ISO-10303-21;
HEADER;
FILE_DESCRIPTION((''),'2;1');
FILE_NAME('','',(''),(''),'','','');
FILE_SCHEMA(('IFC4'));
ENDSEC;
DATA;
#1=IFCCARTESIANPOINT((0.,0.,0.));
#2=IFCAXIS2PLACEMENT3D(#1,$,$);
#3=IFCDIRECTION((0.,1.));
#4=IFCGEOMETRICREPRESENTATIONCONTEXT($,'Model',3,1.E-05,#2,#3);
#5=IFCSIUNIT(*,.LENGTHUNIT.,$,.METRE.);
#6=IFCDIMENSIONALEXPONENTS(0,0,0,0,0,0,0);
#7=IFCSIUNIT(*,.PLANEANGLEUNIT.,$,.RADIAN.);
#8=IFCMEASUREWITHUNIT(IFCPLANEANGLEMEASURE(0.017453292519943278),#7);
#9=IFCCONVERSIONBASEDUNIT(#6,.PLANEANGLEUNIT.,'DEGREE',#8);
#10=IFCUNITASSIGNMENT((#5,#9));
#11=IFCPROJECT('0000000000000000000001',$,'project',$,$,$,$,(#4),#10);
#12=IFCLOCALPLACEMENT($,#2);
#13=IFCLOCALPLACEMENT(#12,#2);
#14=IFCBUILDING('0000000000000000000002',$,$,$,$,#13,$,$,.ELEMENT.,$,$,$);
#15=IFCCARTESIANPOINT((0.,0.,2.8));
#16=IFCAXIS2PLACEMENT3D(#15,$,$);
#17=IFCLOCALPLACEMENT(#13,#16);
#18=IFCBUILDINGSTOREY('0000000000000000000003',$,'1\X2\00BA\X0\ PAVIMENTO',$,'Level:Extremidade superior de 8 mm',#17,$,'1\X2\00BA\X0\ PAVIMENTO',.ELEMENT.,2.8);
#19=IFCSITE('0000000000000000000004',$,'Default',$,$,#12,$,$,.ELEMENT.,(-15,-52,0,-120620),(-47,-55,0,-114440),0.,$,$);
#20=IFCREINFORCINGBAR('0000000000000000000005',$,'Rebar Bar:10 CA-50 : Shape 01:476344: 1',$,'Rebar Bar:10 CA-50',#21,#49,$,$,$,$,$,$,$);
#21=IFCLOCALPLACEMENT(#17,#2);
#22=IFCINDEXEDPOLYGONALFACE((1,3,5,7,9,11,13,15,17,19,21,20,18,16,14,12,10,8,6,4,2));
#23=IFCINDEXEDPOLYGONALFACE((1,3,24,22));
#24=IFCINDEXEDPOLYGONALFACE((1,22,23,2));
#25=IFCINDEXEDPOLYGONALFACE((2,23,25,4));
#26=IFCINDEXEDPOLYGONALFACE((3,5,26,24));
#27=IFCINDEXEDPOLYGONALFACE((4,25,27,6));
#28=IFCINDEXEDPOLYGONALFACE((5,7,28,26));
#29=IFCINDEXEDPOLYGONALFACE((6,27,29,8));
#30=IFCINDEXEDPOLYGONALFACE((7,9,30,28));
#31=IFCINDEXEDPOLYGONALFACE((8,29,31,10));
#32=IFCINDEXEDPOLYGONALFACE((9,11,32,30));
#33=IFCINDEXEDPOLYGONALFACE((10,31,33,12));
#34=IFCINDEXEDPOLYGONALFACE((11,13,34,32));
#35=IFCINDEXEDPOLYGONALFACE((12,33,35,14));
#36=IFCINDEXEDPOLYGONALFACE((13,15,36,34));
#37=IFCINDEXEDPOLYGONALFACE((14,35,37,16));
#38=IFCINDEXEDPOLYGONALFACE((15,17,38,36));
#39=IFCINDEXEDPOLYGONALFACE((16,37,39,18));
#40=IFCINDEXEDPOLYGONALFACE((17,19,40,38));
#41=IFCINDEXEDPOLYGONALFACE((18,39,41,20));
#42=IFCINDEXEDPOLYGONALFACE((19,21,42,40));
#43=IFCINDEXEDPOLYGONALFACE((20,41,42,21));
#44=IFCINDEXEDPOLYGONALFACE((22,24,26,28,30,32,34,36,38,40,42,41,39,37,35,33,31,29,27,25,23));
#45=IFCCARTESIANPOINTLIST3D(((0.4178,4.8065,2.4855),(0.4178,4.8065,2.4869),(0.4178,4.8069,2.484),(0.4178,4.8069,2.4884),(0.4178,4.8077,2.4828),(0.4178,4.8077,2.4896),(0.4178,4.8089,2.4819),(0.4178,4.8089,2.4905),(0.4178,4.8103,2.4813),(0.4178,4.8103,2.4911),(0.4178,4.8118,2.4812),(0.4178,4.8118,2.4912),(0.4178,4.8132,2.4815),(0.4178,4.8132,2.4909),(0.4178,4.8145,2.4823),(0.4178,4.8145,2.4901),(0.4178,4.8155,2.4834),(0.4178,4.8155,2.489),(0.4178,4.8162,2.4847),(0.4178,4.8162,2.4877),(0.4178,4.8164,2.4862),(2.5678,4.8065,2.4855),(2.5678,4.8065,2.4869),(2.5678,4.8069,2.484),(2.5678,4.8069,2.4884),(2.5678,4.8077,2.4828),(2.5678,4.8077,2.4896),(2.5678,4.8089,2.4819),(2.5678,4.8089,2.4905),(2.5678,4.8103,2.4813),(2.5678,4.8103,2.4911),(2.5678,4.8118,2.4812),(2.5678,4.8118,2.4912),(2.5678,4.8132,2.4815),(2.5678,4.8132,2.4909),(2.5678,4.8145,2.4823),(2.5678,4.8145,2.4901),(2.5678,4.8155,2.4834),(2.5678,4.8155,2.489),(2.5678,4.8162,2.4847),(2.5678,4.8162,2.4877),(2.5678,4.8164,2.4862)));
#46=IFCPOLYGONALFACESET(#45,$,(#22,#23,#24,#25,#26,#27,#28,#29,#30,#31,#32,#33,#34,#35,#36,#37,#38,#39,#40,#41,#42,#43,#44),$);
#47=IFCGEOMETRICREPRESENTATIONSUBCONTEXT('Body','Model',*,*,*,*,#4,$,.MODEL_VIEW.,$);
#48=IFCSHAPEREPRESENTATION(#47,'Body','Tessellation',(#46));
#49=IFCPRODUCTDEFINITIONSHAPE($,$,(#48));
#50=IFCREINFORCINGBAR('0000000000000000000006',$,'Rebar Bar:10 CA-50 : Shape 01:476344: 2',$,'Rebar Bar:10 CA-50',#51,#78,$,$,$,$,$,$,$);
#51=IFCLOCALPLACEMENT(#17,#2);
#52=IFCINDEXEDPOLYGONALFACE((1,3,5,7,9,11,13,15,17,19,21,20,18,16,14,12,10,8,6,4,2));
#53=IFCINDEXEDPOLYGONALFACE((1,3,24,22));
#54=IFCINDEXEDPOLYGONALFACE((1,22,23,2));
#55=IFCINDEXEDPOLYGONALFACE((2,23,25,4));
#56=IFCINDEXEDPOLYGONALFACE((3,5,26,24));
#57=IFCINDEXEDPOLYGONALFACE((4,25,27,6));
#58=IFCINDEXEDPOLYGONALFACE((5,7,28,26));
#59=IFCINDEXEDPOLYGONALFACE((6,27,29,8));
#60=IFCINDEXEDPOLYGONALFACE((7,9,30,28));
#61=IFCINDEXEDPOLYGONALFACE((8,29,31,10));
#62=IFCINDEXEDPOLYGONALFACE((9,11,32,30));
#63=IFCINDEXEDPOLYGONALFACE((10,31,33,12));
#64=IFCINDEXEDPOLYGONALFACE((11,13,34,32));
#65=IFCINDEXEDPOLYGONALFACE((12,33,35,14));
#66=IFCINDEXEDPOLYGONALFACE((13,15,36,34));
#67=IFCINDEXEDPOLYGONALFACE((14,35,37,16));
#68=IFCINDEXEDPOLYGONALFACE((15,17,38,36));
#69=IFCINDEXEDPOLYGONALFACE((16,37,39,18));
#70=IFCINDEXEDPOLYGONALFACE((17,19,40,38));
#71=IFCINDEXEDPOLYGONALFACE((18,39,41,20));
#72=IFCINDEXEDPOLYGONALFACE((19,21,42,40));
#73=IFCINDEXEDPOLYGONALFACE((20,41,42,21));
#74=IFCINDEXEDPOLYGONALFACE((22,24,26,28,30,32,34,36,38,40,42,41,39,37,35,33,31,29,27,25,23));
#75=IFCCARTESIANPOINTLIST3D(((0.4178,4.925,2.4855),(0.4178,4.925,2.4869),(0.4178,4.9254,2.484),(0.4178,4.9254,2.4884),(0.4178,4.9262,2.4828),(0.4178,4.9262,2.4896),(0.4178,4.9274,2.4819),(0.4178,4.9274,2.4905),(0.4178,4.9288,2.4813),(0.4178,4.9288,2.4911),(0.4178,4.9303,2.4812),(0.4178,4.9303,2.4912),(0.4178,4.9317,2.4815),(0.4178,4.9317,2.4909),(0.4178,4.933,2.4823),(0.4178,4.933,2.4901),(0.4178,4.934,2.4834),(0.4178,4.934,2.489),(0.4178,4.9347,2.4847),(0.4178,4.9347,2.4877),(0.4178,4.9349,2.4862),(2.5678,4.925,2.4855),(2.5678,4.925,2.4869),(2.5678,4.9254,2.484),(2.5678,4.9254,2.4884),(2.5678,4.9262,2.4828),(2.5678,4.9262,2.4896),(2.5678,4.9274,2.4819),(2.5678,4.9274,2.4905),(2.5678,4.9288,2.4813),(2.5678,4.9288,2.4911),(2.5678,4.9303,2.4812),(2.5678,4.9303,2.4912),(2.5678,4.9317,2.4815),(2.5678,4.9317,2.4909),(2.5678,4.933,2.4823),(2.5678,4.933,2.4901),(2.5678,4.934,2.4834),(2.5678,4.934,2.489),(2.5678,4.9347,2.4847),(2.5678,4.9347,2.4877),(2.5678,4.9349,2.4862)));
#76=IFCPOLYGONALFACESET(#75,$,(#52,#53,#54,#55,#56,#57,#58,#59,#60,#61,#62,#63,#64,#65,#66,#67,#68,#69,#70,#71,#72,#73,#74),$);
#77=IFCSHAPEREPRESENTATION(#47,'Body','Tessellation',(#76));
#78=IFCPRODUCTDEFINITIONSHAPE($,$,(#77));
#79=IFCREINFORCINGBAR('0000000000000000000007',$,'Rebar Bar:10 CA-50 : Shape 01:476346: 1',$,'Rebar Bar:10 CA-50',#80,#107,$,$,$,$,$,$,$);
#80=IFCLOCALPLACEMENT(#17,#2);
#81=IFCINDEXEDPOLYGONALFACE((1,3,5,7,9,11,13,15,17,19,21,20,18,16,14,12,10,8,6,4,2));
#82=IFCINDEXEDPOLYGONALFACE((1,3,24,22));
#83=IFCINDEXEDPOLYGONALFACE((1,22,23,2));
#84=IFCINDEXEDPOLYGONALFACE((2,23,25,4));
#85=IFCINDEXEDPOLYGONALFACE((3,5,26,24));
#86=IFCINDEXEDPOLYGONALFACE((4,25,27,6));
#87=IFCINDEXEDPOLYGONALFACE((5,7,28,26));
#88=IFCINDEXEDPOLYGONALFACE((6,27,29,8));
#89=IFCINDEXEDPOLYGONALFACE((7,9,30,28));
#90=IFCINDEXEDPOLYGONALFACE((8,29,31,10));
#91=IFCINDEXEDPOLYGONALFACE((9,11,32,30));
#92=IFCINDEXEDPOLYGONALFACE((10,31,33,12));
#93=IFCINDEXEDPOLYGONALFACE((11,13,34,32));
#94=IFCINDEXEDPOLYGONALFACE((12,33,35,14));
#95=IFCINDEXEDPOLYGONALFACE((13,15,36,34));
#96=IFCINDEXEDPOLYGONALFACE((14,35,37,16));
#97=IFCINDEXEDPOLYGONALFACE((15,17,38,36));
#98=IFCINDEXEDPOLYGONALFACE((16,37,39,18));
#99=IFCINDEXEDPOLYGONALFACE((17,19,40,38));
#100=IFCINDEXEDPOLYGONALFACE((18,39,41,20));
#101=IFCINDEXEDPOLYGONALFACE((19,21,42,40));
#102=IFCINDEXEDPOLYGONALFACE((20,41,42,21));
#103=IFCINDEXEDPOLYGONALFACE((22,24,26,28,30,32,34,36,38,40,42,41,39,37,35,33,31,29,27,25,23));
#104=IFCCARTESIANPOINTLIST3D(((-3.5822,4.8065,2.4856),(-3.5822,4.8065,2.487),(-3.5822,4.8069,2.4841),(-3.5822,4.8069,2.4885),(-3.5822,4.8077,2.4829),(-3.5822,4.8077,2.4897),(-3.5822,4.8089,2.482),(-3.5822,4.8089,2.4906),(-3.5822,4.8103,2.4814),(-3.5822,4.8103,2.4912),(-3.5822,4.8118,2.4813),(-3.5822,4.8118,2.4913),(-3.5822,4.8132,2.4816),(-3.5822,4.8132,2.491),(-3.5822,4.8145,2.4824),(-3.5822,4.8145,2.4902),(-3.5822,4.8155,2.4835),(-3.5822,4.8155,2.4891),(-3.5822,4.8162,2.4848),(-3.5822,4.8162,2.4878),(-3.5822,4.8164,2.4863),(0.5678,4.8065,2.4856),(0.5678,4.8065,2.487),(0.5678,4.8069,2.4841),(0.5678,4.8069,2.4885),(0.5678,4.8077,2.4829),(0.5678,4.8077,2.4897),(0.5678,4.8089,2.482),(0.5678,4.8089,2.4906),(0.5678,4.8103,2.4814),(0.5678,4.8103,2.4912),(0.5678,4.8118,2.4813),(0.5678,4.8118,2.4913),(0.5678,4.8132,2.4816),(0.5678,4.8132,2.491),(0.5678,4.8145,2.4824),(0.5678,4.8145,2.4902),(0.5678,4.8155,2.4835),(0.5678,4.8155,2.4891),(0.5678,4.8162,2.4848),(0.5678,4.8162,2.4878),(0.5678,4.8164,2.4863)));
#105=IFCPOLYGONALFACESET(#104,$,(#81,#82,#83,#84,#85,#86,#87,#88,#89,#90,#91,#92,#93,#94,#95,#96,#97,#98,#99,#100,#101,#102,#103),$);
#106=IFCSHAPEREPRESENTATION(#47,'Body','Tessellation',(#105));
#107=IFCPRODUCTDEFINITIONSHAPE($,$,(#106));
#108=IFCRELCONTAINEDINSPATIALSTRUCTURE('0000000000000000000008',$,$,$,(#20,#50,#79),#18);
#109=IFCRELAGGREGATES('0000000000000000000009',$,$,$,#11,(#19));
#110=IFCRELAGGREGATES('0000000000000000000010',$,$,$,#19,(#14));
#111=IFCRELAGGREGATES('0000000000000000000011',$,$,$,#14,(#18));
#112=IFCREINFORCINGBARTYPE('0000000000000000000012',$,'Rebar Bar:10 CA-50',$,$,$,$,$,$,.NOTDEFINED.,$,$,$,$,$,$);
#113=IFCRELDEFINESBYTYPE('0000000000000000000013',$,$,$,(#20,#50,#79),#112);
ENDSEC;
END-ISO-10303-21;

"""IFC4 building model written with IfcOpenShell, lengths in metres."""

from ifc_helpers import new_model, entity, si_unit, converted_unit, direction, frame, origin, place, context, subcontext, project, spatial, type_object, element, save


model = new_model("IFC4")

# Units and contexts
model_context = context("Model", 3, precision=1e-05, world=origin(), true_north=direction((0.0, 1.0)))
body_context = subcontext(model_context, "Body", "Model", "MODEL_VIEW")
ifc_project = project(units=[si_unit("LENGTHUNIT", "METRE"), converted_unit("PLANEANGLEUNIT", "DEGREE", entity("IfcPlaneAngleMeasure", 0.017453292519943278), si_unit("PLANEANGLEUNIT", "RADIAN"), dimensions=[0, 0, 0, 0, 0, 0, 0])], contexts=[model_context])

# Site, building, storey
site_placement = place(None, origin())
site = spatial("IfcSite", under=ifc_project, at=site_placement, Name="Default", CompositionType="ELEMENT", RefLatitude=(-15, -52, 0, -120620), RefLongitude=(-47, -55, 0, -114440), RefElevation=0.0)
building_placement = place(site_placement, origin())
building = spatial("IfcBuilding", under=site, at=building_placement, CompositionType="ELEMENT")
storey_placement = place(building_placement, frame((0.0, 0.0, 2.8)))
storey = spatial("IfcBuildingStorey", under=building, at=storey_placement, Name="1º PAVIMENTO", ObjectType="Level:Extremidade superior de 8 mm", LongName="1º PAVIMENTO", CompositionType="ELEMENT", Elevation=2.8)

# Reinforcing bars
reinforcing_bar_type_1 = type_object("IfcReinforcingBarType", Name="Rebar Bar:10 CA-50", PredefinedType="NOTDEFINED")
reinforcing_bar_1_placement = place(storey_placement, origin())
element("IfcReinforcingBar", 1, at=reinforcing_bar_1_placement, inside=storey, type_object=reinforcing_bar_type_1, Name="Rebar Bar:10 CA-50 : Shape 01:476344: 1", ObjectType="Rebar Bar:10 CA-50", context=body_context, shape_type="AdvancedSweptSolid", body=[
    entity("IfcSweptDiskSolid", entity("IfcIndexedPolyCurve", entity("IfcCartesianPointList3D", [[0.4178, 4.8114, 2.4862], [2.5678, 4.8114, 2.4862]]), None, False), 0.005, None, 0.0, 1.0),
])
reinforcing_bar_2_placement = place(storey_placement, origin())
element("IfcReinforcingBar", 2, at=reinforcing_bar_2_placement, inside=storey, type_object=reinforcing_bar_type_1, Name="Rebar Bar:10 CA-50 : Shape 01:476344: 2", ObjectType="Rebar Bar:10 CA-50", context=body_context, shape_type="AdvancedSweptSolid", body=[
    entity("IfcSweptDiskSolid", entity("IfcIndexedPolyCurve", entity("IfcCartesianPointList3D", [[0.4178, 4.9299, 2.4862], [2.5678, 4.9299, 2.4862]]), None, False), 0.005, None, 0.0, 1.0),
])
reinforcing_bar_3_placement = place(storey_placement, origin())
element("IfcReinforcingBar", 3, at=reinforcing_bar_3_placement, inside=storey, type_object=reinforcing_bar_type_1, Name="Rebar Bar:10 CA-50 : Shape 01:476346: 1", ObjectType="Rebar Bar:10 CA-50", context=body_context, shape_type="AdvancedSweptSolid", body=[
    entity("IfcSweptDiskSolid", entity("IfcIndexedPolyCurve", entity("IfcCartesianPointList3D", [[-3.5822, 4.8114, 2.4863], [0.5678, 4.8114, 2.4863]]), None, False), 0.005, None, 0.0, 1.0),
])

save(model, "model.ifc")
